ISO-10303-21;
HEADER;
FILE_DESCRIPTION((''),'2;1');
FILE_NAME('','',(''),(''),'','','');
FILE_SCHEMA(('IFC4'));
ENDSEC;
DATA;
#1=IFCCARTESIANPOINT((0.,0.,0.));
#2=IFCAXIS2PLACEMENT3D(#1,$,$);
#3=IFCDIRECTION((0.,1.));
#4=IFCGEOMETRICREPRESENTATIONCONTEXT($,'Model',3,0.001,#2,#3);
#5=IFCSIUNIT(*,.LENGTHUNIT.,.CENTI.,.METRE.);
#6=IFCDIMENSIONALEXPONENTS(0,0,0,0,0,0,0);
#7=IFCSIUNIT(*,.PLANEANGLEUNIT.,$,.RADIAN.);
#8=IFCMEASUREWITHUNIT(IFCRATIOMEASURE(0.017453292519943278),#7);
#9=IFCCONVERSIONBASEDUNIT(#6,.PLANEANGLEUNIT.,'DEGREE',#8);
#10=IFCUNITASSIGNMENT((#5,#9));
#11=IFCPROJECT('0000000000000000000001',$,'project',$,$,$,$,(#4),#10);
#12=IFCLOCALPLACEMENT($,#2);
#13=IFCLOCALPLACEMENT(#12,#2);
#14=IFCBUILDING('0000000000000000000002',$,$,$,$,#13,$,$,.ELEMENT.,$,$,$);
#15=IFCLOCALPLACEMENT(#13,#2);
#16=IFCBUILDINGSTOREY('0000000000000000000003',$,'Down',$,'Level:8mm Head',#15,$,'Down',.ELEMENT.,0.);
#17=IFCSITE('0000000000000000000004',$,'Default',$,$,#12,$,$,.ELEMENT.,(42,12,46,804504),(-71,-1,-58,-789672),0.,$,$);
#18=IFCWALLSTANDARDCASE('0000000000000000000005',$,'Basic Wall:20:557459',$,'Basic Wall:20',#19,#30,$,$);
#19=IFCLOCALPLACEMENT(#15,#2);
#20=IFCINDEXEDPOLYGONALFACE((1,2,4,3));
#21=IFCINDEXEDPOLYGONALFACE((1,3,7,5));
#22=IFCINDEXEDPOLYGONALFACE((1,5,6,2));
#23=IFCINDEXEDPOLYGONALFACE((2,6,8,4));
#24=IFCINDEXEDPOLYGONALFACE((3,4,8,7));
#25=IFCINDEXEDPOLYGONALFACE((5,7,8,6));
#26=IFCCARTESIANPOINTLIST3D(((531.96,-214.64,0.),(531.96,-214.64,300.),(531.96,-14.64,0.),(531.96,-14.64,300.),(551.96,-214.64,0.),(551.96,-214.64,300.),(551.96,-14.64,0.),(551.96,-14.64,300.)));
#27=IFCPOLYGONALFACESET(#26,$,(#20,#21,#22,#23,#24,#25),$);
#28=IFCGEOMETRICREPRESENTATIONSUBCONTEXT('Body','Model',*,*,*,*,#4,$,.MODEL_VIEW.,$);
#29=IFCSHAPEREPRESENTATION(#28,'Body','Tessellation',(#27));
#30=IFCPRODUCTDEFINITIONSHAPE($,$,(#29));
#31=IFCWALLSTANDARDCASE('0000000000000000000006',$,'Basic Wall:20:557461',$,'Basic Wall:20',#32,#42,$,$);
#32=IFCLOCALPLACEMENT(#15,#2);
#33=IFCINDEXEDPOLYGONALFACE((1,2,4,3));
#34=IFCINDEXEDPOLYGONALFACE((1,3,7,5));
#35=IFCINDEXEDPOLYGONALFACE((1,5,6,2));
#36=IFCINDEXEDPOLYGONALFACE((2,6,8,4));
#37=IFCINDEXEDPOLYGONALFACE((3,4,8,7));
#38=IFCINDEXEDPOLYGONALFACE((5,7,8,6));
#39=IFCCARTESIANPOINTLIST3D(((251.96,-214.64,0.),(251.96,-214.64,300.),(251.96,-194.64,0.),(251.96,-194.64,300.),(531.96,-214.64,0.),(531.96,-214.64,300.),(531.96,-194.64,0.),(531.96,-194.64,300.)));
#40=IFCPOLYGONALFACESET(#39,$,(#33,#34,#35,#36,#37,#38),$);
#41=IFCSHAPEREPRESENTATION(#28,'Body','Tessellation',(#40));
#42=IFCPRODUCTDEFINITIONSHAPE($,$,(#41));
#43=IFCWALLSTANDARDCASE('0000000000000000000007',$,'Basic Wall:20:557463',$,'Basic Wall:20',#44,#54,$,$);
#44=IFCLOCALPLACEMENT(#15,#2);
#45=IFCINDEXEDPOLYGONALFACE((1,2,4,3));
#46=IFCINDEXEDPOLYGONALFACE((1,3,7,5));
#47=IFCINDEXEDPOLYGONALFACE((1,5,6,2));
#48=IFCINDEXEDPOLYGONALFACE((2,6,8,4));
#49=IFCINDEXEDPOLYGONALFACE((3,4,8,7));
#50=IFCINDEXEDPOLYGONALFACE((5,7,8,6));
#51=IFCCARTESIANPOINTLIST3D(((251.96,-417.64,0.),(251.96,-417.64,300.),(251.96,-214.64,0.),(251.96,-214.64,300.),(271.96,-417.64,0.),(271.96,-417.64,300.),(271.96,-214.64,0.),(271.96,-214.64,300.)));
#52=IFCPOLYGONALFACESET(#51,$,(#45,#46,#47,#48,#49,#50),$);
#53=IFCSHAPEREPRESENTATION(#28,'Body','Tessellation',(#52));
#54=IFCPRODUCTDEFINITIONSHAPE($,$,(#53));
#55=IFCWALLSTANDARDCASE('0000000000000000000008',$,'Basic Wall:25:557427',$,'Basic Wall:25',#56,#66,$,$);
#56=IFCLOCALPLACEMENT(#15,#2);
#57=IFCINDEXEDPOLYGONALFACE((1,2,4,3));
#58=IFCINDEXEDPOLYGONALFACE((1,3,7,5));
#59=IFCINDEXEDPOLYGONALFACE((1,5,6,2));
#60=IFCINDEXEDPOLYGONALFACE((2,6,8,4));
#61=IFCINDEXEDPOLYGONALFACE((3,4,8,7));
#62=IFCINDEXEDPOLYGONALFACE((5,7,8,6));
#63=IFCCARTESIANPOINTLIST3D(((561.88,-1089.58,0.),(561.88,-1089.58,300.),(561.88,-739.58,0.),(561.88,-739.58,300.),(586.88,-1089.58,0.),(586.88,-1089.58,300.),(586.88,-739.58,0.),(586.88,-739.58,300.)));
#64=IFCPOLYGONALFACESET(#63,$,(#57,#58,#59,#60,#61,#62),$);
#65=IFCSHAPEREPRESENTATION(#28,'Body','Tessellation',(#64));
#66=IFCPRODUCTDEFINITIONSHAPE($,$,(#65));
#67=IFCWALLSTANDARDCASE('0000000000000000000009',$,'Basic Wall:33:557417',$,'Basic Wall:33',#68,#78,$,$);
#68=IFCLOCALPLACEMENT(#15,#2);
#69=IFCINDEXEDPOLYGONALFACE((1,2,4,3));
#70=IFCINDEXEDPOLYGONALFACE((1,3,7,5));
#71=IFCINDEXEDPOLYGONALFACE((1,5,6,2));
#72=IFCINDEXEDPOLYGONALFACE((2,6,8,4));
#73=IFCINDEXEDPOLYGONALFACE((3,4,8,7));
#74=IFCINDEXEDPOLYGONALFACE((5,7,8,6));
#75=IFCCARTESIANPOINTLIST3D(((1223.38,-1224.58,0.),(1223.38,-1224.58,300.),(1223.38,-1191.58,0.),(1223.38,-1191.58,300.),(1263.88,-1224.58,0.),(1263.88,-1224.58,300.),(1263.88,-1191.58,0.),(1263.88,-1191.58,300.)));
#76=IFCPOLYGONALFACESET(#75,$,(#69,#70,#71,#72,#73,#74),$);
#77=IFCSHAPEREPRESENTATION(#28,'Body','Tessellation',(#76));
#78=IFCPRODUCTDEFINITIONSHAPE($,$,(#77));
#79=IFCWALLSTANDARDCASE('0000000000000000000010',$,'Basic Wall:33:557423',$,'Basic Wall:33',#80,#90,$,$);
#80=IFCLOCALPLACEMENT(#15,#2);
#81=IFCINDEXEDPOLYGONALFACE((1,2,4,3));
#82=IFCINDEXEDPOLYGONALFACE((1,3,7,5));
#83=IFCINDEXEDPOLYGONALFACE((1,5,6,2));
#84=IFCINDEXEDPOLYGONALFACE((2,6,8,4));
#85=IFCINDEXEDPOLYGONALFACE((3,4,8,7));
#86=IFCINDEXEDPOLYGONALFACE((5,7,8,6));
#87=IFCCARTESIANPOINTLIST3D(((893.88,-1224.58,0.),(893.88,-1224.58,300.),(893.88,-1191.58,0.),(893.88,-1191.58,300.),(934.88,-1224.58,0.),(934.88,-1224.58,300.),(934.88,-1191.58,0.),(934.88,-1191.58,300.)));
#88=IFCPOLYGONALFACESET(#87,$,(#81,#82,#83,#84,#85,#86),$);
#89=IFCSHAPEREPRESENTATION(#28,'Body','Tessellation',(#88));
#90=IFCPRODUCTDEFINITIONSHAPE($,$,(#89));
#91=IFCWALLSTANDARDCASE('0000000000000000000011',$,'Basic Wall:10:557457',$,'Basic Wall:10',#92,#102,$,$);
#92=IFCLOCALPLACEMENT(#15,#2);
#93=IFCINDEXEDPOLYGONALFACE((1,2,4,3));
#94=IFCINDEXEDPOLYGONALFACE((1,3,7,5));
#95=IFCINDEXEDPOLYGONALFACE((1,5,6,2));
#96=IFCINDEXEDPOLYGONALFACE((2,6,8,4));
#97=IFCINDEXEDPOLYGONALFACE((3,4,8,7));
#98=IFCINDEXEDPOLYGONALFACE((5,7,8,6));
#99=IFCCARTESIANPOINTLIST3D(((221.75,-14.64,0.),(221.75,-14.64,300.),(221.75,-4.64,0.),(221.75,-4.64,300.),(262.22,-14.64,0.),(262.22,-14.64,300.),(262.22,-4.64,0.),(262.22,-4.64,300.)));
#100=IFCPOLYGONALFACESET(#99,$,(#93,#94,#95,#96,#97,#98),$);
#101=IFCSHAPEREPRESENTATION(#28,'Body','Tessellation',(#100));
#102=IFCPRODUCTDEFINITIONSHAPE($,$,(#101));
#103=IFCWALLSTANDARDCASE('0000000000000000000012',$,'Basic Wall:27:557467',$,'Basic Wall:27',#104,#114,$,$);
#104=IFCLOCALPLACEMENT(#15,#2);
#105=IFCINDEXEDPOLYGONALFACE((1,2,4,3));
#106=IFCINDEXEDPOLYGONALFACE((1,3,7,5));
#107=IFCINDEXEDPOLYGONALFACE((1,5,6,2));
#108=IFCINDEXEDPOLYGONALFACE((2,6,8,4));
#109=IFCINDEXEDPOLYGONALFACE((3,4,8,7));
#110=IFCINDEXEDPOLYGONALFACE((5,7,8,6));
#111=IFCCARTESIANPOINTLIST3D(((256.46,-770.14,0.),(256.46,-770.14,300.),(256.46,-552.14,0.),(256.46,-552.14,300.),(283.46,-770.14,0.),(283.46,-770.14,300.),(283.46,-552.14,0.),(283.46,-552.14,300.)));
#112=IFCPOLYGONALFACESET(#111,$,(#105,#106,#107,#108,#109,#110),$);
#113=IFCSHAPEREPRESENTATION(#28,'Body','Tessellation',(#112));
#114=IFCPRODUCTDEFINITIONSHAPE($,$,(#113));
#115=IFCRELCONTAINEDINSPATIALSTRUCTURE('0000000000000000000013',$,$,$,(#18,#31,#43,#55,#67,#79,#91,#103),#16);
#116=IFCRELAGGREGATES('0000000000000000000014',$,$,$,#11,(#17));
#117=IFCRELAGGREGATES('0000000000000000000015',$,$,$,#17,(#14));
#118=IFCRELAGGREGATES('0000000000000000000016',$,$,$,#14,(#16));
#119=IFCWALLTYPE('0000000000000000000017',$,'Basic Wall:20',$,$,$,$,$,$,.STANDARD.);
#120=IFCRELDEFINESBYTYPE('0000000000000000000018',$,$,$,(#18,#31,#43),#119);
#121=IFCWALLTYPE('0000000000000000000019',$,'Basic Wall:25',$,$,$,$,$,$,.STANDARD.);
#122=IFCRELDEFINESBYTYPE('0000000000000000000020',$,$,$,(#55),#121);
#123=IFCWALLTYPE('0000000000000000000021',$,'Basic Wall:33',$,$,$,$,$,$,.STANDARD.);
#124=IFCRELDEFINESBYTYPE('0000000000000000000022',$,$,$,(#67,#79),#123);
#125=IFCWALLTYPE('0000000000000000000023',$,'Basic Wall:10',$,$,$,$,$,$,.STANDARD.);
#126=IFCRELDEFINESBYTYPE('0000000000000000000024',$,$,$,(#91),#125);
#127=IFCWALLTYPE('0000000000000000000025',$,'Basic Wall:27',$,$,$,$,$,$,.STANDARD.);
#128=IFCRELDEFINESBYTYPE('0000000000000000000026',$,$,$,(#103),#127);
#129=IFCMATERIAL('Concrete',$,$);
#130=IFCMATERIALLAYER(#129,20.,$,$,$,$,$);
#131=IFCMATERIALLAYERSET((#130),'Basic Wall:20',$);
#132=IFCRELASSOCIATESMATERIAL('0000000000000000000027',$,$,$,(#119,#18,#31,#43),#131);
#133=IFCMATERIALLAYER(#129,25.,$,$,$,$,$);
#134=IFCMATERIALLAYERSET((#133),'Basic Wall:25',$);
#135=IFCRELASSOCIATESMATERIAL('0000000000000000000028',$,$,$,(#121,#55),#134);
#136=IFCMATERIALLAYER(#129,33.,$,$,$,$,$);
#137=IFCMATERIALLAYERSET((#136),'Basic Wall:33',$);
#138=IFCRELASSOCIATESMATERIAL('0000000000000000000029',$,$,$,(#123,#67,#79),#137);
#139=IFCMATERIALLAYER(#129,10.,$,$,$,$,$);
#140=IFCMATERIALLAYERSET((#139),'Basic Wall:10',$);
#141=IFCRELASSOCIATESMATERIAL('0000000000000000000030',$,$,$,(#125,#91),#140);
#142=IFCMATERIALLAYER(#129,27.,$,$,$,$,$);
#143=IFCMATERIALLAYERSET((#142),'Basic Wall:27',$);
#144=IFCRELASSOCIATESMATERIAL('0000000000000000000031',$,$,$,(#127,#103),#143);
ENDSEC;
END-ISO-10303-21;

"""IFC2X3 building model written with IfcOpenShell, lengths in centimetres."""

from ifc_helpers import new_model, entity, si_unit, converted_unit, direction, frame, frame_2d, origin, place, context, subcontext, project, spatial, rectangle, extrude, material, layer, layer_set, layer_usage, type_object, element, save


model = new_model("IFC2X3")

# Units and contexts
model_context = context("Model", 3, precision=0.001, world=origin(), true_north=direction((0.0, 1.0)))
body_context = subcontext(model_context, "Body", "Model", "MODEL_VIEW")
ifc_project = project(units=[si_unit("LENGTHUNIT", "METRE", prefix="CENTI"), converted_unit("PLANEANGLEUNIT", "DEGREE", entity("IfcRatioMeasure", 0.017453292519943278), si_unit("PLANEANGLEUNIT", "RADIAN"), dimensions=[0, 0, 0, 0, 0, 0, 0])], contexts=[model_context])

# Site, building, storey
site_placement = place(None, origin())
site = spatial("IfcSite", under=ifc_project, at=site_placement, Name="Default", CompositionType="ELEMENT", RefLatitude=(42, 12, 46, 804504), RefLongitude=(-71, -1, -58, -789672), RefElevation=0.0)
building_placement = place(site_placement, origin())
building = spatial("IfcBuilding", under=site, at=building_placement, CompositionType="ELEMENT")
storey_placement = place(building_placement, origin())
storey = spatial("IfcBuildingStorey", under=building, at=storey_placement, Name="Down", ObjectType="Level:8mm Head", LongName="Down", CompositionType="ELEMENT", Elevation=0.0)

# Walls
ifc_material = material(Name="Concrete")
ifc_layer_1 = layer(ifc_material, 20.0)
ifc_layer_set_1 = layer_set([ifc_layer_1], Name="Basic Wall:20")
wall_type_1 = type_object("IfcWallType", Name="Basic Wall:20", PredefinedType="STANDARD", material=ifc_layer_set_1)
ifc_layer_usage_1 = layer_usage(ifc_layer_set_1, "AXIS2", "NEGATIVE", 10.0)
wall_1_placement = place(storey_placement, frame((541.96, -14.64, 0.0), z_axis=(0.0, 0.0, 1.0), x_axis=(0.0, -1.0, 0.0)))
element("IfcWallStandardCase", 1, at=wall_1_placement, inside=storey, type_object=wall_type_1, material=ifc_layer_usage_1, Name="Basic Wall:20:557459", ObjectType="Basic Wall:20", context=body_context, shape_type="SweptSolid", body=[
    extrude(rectangle(XDim=200.0, YDim=20.0, at=frame_2d((100.0, 0.0), x_axis=(-1.0, 0.0))), origin(), (0.0, 0.0, 1.0), 300.0),
])
ifc_layer_usage_2 = layer_usage(ifc_layer_set_1, "AXIS2", "NEGATIVE", 10.0)
wall_2_placement = place(storey_placement, frame((531.96, -204.64, 0.0), z_axis=(0.0, 0.0, 1.0), x_axis=(-1.0, 0.0, 0.0)))
element("IfcWallStandardCase", 2, at=wall_2_placement, inside=storey, type_object=wall_type_1, material=ifc_layer_usage_2, Name="Basic Wall:20:557461", ObjectType="Basic Wall:20", context=body_context, shape_type="SweptSolid", body=[
    extrude(rectangle(XDim=280.0, YDim=20.0, at=frame_2d((140.0, 0.0), x_axis=(-1.0, 0.0))), origin(), (0.0, 0.0, 1.0), 300.0),
])
ifc_layer_usage_3 = layer_usage(ifc_layer_set_1, "AXIS2", "POSITIVE", -10.0)
wall_3_placement = place(storey_placement, frame((261.96, -214.64, 0.0), z_axis=(0.0, 0.0, 1.0), x_axis=(0.0, -1.0, 0.0)))
element("IfcWallStandardCase", 3, at=wall_3_placement, inside=storey, type_object=wall_type_1, material=ifc_layer_usage_3, Name="Basic Wall:20:557463", ObjectType="Basic Wall:20", context=body_context, shape_type="SweptSolid", body=[
    extrude(rectangle(XDim=203.0, YDim=20.0, at=frame_2d((101.5, 0.0), x_axis=(-1.0, 0.0))), origin(), (0.0, 0.0, 1.0), 300.0),
])
ifc_layer_2 = layer(ifc_material, 25.0)
ifc_layer_set_2 = layer_set([ifc_layer_2], Name="Basic Wall:25")
ifc_layer_usage_4 = layer_usage(ifc_layer_set_2, "AXIS2", "NEGATIVE", 12.5)
wall_type_2 = type_object("IfcWallType", Name="Basic Wall:25", PredefinedType="STANDARD", material=ifc_layer_set_2)
wall_4_placement = place(storey_placement, frame((574.38, -1089.58, 0.0), z_axis=(0.0, 0.0, 1.0), x_axis=(0.0, 1.0, 0.0)))
element("IfcWallStandardCase", 4, at=wall_4_placement, inside=storey, type_object=wall_type_2, material=ifc_layer_usage_4, Name="Basic Wall:25:557427", ObjectType="Basic Wall:25", context=body_context, shape_type="SweptSolid", body=[
    extrude(rectangle(XDim=350.0, YDim=25.0, at=frame_2d((175.0, 0.0), x_axis=(-1.0, 0.0))), origin(), (0.0, 0.0, 1.0), 300.0),
])
ifc_layer_3 = layer(ifc_material, 33.0)
ifc_layer_set_3 = layer_set([ifc_layer_3], Name="Basic Wall:33")
ifc_layer_usage_5 = layer_usage(ifc_layer_set_3, "AXIS2", "POSITIVE", -16.5)
wall_type_3 = type_object("IfcWallType", Name="Basic Wall:33", PredefinedType="STANDARD", material=ifc_layer_set_3)
wall_5_placement = place(storey_placement, frame((1263.88, -1208.08, 0.0), z_axis=(0.0, 0.0, 1.0), x_axis=(-1.0, 0.0, 0.0)))
element("IfcWallStandardCase", 5, at=wall_5_placement, inside=storey, type_object=wall_type_3, material=ifc_layer_usage_5, Name="Basic Wall:33:557417", ObjectType="Basic Wall:33", context=body_context, shape_type="SweptSolid", body=[
    extrude(rectangle(XDim=40.5, YDim=33.0, at=frame_2d((20.25, 0.0), x_axis=(-1.0, 0.0))), origin(), (0.0, 0.0, 1.0), 300.0),
])
ifc_layer_usage_6 = layer_usage(ifc_layer_set_3, "AXIS2", "NEGATIVE", 16.5)
wall_6_placement = place(storey_placement, frame((893.88, -1208.08, 0.0)))
element("IfcWallStandardCase", 6, at=wall_6_placement, inside=storey, type_object=wall_type_3, material=ifc_layer_usage_6, Name="Basic Wall:33:557423", ObjectType="Basic Wall:33", context=body_context, shape_type="SweptSolid", body=[
    extrude(rectangle(XDim=41.0, YDim=33.0, at=frame_2d((20.5, 0.0), x_axis=(-1.0, 0.0))), origin(), (0.0, 0.0, 1.0), 300.0),
])
ifc_layer_4 = layer(ifc_material, 10.0)
ifc_layer_set_4 = layer_set([ifc_layer_4], Name="Basic Wall:10")
ifc_layer_usage_7 = layer_usage(ifc_layer_set_4, "AXIS2", "NEGATIVE", 5.0)
wall_type_4 = type_object("IfcWallType", Name="Basic Wall:10", PredefinedType="STANDARD", material=ifc_layer_set_4)
wall_7_placement = place(storey_placement, frame((262.22, -9.64, 0.0), z_axis=(0.0, 0.0, 1.0), x_axis=(-1.0, 0.0, 0.0)))
element("IfcWallStandardCase", 7, at=wall_7_placement, inside=storey, type_object=wall_type_4, material=ifc_layer_usage_7, Name="Basic Wall:10:557457", ObjectType="Basic Wall:10", context=body_context, shape_type="SweptSolid", body=[
    extrude(rectangle(XDim=40.47, YDim=10.0, at=frame_2d((20.24, 0.0), x_axis=(-1.0, 0.0))), origin(), (0.0, 0.0, 1.0), 300.0),
])
ifc_layer_5 = layer(ifc_material, 27.0)
ifc_layer_set_5 = layer_set([ifc_layer_5], Name="Basic Wall:27")
ifc_layer_usage_8 = layer_usage(ifc_layer_set_5, "AXIS2", "POSITIVE", -13.5)
wall_type_5 = type_object("IfcWallType", Name="Basic Wall:27", PredefinedType="STANDARD", material=ifc_layer_set_5)
wall_8_placement = place(storey_placement, frame((269.96, -552.14, 0.0), z_axis=(0.0, 0.0, 1.0), x_axis=(0.0, -1.0, 0.0)))
element("IfcWallStandardCase", 8, at=wall_8_placement, inside=storey, type_object=wall_type_5, material=ifc_layer_usage_8, Name="Basic Wall:27:557467", ObjectType="Basic Wall:27", context=body_context, shape_type="SweptSolid", body=[
    extrude(rectangle(XDim=218.0, YDim=27.0, at=frame_2d((109.0, 0.0), x_axis=(-1.0, 0.0))), origin(), (0.0, 0.0, 1.0), 300.0),
])

save(model, "model.ifc")
